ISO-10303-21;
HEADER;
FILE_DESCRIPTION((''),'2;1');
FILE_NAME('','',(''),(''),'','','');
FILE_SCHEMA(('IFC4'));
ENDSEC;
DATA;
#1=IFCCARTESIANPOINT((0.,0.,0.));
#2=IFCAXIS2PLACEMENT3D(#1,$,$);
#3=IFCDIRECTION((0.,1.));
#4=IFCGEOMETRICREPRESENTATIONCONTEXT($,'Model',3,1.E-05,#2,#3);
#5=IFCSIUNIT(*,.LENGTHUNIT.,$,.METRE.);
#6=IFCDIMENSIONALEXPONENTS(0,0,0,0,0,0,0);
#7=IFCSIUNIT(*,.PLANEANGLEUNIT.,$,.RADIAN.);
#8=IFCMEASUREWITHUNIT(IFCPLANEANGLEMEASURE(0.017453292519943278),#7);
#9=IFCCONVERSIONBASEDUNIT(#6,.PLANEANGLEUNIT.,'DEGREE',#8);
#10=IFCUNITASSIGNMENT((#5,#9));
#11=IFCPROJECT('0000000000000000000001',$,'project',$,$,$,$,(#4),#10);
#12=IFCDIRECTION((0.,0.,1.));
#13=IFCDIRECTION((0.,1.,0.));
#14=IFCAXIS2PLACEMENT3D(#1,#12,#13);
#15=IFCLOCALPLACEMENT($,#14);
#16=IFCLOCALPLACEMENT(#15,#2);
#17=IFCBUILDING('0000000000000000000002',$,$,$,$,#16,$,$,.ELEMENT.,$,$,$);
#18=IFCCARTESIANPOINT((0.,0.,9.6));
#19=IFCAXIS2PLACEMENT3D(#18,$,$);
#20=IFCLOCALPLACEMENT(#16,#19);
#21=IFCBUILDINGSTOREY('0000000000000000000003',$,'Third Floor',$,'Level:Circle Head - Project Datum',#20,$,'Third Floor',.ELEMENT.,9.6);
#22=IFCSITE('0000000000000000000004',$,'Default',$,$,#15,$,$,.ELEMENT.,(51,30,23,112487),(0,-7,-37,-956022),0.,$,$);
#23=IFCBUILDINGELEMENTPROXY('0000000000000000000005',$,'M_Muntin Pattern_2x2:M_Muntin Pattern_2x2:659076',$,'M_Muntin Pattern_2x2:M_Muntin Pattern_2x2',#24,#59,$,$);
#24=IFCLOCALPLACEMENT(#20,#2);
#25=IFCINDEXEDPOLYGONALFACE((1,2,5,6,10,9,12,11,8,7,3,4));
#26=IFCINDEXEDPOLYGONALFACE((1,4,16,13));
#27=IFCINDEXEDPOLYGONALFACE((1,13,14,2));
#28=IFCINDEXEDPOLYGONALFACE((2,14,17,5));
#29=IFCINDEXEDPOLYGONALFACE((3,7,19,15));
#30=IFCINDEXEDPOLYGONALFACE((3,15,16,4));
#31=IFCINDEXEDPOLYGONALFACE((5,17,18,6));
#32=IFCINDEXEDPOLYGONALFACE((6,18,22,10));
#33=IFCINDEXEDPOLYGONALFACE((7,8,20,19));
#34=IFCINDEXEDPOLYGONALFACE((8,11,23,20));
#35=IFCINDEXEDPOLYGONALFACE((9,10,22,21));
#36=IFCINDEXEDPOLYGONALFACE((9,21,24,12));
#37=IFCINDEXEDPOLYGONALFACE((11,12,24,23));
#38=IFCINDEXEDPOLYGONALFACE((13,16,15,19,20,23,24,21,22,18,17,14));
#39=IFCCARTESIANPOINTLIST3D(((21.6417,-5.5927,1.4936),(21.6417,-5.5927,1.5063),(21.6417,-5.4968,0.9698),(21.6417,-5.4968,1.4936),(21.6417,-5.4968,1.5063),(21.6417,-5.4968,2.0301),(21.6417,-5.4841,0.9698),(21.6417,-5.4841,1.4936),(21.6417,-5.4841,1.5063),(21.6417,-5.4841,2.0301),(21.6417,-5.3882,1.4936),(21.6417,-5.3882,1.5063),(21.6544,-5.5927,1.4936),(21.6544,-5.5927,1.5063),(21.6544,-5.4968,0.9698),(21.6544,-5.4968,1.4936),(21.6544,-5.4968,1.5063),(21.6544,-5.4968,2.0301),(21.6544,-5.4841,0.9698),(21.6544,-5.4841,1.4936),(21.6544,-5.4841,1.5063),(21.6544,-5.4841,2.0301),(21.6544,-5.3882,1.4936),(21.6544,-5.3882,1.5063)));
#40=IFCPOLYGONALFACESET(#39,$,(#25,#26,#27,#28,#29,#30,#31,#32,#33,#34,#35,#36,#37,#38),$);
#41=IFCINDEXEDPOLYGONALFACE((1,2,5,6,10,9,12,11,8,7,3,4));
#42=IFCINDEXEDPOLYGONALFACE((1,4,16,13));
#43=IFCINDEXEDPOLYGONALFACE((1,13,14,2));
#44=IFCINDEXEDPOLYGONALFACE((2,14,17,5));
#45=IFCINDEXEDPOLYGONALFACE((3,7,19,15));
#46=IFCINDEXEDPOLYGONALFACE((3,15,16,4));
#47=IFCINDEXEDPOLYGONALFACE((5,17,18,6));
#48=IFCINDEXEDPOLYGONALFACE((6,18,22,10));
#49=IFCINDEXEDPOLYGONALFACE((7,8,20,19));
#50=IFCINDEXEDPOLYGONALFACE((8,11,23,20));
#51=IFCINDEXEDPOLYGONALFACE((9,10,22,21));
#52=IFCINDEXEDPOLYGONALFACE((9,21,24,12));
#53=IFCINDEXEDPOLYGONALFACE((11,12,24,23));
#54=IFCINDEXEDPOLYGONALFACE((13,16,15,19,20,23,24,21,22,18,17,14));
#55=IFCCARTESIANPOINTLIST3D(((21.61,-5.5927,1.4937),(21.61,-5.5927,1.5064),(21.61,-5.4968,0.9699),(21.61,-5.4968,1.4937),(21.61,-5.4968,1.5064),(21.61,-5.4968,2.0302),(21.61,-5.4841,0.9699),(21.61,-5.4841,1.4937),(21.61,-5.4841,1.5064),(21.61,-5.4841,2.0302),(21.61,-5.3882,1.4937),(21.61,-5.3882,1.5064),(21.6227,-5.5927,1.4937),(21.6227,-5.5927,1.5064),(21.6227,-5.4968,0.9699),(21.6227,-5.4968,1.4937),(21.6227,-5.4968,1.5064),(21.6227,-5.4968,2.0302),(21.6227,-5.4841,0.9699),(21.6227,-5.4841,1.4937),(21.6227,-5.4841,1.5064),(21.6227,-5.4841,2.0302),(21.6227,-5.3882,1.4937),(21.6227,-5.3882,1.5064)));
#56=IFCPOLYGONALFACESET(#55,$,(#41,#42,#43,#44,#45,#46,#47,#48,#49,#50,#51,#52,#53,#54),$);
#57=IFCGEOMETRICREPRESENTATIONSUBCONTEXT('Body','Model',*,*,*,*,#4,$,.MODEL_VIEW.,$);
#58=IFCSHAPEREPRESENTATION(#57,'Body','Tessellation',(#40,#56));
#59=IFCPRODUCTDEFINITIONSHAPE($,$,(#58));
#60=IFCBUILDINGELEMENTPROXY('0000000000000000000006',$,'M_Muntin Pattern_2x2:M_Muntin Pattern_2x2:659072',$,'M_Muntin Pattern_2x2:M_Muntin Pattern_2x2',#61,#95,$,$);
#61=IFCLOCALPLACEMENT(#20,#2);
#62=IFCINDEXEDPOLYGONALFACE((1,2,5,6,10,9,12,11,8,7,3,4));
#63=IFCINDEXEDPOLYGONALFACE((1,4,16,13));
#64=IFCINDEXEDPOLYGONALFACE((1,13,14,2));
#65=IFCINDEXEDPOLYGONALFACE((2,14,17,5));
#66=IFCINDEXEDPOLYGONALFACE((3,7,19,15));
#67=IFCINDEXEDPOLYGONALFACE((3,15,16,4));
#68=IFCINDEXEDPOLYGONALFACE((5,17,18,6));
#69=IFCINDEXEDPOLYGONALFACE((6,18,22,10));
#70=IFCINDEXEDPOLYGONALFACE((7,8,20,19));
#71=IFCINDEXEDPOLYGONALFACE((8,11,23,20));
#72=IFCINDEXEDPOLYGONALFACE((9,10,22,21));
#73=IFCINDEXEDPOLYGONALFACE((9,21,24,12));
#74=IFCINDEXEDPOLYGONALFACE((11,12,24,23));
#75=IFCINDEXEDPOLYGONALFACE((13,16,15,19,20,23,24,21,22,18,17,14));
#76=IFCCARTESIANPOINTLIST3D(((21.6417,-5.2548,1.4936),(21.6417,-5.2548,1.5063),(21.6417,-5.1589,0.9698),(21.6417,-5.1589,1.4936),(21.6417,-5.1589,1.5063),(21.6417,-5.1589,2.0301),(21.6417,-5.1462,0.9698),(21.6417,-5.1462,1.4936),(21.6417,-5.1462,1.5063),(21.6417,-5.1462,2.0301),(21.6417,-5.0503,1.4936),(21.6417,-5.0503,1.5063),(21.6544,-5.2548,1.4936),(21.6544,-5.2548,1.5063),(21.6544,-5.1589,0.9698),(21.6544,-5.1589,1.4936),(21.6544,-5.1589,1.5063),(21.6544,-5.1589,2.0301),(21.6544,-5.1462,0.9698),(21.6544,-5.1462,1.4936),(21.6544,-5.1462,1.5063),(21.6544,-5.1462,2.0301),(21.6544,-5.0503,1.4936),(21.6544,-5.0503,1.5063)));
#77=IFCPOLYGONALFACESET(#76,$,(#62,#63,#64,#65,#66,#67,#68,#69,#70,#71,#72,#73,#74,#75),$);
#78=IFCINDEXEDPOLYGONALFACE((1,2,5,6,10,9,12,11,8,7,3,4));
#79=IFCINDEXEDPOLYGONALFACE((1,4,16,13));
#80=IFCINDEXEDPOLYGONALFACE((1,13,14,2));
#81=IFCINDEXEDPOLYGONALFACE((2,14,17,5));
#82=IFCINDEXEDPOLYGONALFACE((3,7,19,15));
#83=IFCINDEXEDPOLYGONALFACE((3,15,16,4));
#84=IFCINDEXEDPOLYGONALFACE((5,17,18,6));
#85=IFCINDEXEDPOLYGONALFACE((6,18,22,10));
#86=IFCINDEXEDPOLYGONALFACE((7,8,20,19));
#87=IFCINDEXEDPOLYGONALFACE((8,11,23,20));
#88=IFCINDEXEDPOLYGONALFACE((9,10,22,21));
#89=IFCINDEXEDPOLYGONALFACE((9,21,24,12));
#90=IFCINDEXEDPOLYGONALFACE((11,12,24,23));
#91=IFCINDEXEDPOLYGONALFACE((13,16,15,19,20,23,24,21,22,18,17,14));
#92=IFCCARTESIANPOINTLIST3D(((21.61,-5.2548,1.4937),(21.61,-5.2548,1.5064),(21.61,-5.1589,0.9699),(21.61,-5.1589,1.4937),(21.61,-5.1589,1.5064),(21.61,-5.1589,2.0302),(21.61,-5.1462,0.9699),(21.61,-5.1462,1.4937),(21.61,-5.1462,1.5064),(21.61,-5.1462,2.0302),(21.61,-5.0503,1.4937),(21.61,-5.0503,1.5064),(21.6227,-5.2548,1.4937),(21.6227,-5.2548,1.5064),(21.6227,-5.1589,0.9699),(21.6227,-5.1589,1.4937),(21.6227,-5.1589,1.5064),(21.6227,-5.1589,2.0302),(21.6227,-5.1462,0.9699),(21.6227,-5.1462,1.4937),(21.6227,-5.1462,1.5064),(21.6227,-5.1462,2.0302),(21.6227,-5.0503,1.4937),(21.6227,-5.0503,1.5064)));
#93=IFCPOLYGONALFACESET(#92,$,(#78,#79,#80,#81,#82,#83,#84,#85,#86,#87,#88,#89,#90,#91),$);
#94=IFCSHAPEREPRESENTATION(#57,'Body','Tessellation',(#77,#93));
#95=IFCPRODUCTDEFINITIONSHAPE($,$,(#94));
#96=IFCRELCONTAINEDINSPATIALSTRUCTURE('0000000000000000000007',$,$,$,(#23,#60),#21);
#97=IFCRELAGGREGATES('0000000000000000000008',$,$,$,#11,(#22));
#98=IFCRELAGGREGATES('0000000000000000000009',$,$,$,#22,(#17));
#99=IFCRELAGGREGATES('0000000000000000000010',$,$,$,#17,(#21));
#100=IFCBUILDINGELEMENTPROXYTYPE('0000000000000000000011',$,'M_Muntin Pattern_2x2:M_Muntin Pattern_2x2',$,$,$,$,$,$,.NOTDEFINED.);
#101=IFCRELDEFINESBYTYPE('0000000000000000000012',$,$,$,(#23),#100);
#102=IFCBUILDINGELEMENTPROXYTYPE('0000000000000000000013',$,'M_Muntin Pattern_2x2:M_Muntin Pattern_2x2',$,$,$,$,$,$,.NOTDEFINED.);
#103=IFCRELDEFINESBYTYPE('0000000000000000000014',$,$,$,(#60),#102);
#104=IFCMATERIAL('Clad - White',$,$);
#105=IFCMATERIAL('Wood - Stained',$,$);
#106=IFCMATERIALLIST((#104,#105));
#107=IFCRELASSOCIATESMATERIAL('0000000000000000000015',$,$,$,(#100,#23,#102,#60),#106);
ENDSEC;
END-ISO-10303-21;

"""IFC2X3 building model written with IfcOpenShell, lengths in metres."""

from ifc_helpers import new_model, entity, si_unit, converted_unit, direction, frame, origin, place, context, subcontext, project, spatial, polyline, outline, extrude, source, transform, mapped, material, material_list, type_object, type_shapes, element, save


model = new_model("IFC2X3")

# Units and contexts
model_context = context("Model", 3, precision=1e-05, world=origin(), true_north=direction((0.0, 1.0)))
body_context = subcontext(model_context, "Body", "Model", "MODEL_VIEW")
ifc_project = project(units=[si_unit("LENGTHUNIT", "METRE"), converted_unit("PLANEANGLEUNIT", "DEGREE", entity("IfcPlaneAngleMeasure", 0.017453292519943278), si_unit("PLANEANGLEUNIT", "RADIAN"), dimensions=[0, 0, 0, 0, 0, 0, 0])], contexts=[model_context])

# Site, building, storey
site_placement = place(None, frame((0.0, 0.0, 0.0), z_axis=(0.0, 0.0, 1.0), x_axis=(0.0, 1.0, 0.0)))
site = spatial("IfcSite", under=ifc_project, at=site_placement, Name="Default", CompositionType="ELEMENT", RefLatitude=(51, 30, 23, 112487), RefLongitude=(0, -7, -37, -956022), RefElevation=0.0)
building_placement = place(site_placement, origin())
building = spatial("IfcBuilding", under=site, at=building_placement, CompositionType="ELEMENT")
storey_placement = place(building_placement, frame((0.0, 0.0, 9.6)))
storey = spatial("IfcBuildingStorey", under=building, at=storey_placement, Name="Third Floor", ObjectType="Level:Circle Head - Project Datum", LongName="Third Floor", CompositionType="ELEMENT", Elevation=9.6)

# Building element proxies
ifc_material_1 = material(Name="Clad - White")
ifc_material_2 = material(Name="Wood - Stained")
ifc_material_list = material_list([ifc_material_1, ifc_material_2])
building_element_proxy_type_1 = type_object("IfcBuildingElementProxyType", Name="M_Muntin Pattern_2x2:M_Muntin Pattern_2x2", PredefinedType="NOTDEFINED", material=ifc_material_list)
shared_shape_1 = source(origin(), body_context, "Body", "SweptSolid", [
    extrude(outline(polyline([(0.0064, -0.0064), (0.5301, -0.0064), (0.5301, 0.0063), (0.0064, 0.0063), (0.0064, 0.1023), (-0.0063, 0.1023), (-0.0063, 0.0063), (-0.5302, 0.0063), (-0.5302, -0.0064), (-0.0063, -0.0064), (-0.0063, -0.1023), (0.0064, -0.1023), (0.0064, -0.0064)])), frame((0.0, -0.0222, 0.5301), z_axis=(0.0, 1.0, 0.0), x_axis=(0.0, 0.0, 1.0)), (0.0, 0.0, 1.0), 0.0127),
    extrude(outline(polyline([(0.0064, -0.0064), (0.5302, -0.0064), (0.5302, 0.0063), (0.0064, 0.0063), (0.0064, 0.1023), (-0.0063, 0.1023), (-0.0063, 0.0063), (-0.5302, 0.0063), (-0.5302, -0.0064), (-0.0063, -0.0064), (-0.0063, -0.1023), (0.0064, -0.1023), (0.0064, -0.0064)])), frame((0.0, 0.0095, 0.5302), z_axis=(0.0, 1.0, 0.0), x_axis=(0.0, 0.0, 1.0)), (0.0, 0.0, 1.0), 0.0127),
])
type_shapes(building_element_proxy_type_1, [shared_shape_1])
proxy_1_placement = place(storey_placement, frame((21.6322, -5.4904, 0.9699), z_axis=(0.0, 0.0, 1.0), x_axis=(0.0, 1.0, 0.0)))
element("IfcBuildingElementProxy", 1, at=proxy_1_placement, inside=storey, type_object=building_element_proxy_type_1, material=ifc_material_list, Name="M_Muntin Pattern_2x2:M_Muntin Pattern_2x2:659076", ObjectType="M_Muntin Pattern_2x2:M_Muntin Pattern_2x2", context=body_context, shape_type="MappedRepresentation", body=[
    mapped(shared_shape_1, transform((0.0, 0.0, 0.0), scale=1.0)),
])
building_element_proxy_type_2 = type_object("IfcBuildingElementProxyType", Name="M_Muntin Pattern_2x2:M_Muntin Pattern_2x2", PredefinedType="NOTDEFINED", material=ifc_material_list)
shared_shape_2 = source(origin(), body_context, "Body", "SweptSolid", [
    extrude(outline(polyline([(0.0064, -0.0064), (0.5301, -0.0064), (0.5301, 0.0063), (0.0064, 0.0063), (0.0064, 0.1023), (-0.0063, 0.1023), (-0.0063, 0.0063), (-0.5302, 0.0063), (-0.5302, -0.0064), (-0.0063, -0.0064), (-0.0063, -0.1023), (0.0064, -0.1023), (0.0064, -0.0064)])), frame((0.0, 0.0095, 0.5301), z_axis=(0.0, 1.0, 0.0), x_axis=(0.0, 0.0, 1.0)), (0.0, 0.0, 1.0), 0.0127),
    extrude(outline(polyline([(0.0064, -0.0064), (0.5302, -0.0064), (0.5302, 0.0063), (0.0064, 0.0063), (0.0064, 0.1023), (-0.0063, 0.1023), (-0.0063, 0.0063), (-0.5302, 0.0063), (-0.5302, -0.0064), (-0.0063, -0.0064), (-0.0063, -0.1023), (0.0064, -0.1023), (0.0064, -0.0064)])), frame((0.0, -0.0222, 0.5302), z_axis=(0.0, 1.0, 0.0), x_axis=(0.0, 0.0, 1.0)), (0.0, 0.0, 1.0), 0.0127),
])
type_shapes(building_element_proxy_type_2, [shared_shape_2])
proxy_2_placement = place(storey_placement, frame((21.6322, -5.1525, 0.9699), z_axis=(0.0, 0.0, 1.0), x_axis=(0.0, -1.0, 0.0)))
element("IfcBuildingElementProxy", 2, at=proxy_2_placement, inside=storey, type_object=building_element_proxy_type_2, material=ifc_material_list, Name="M_Muntin Pattern_2x2:M_Muntin Pattern_2x2:659072", ObjectType="M_Muntin Pattern_2x2:M_Muntin Pattern_2x2", context=body_context, shape_type="MappedRepresentation", body=[
    mapped(shared_shape_2, transform((0.0, 0.0, 0.0), scale=1.0)),
])

save(model, "model.ifc")
